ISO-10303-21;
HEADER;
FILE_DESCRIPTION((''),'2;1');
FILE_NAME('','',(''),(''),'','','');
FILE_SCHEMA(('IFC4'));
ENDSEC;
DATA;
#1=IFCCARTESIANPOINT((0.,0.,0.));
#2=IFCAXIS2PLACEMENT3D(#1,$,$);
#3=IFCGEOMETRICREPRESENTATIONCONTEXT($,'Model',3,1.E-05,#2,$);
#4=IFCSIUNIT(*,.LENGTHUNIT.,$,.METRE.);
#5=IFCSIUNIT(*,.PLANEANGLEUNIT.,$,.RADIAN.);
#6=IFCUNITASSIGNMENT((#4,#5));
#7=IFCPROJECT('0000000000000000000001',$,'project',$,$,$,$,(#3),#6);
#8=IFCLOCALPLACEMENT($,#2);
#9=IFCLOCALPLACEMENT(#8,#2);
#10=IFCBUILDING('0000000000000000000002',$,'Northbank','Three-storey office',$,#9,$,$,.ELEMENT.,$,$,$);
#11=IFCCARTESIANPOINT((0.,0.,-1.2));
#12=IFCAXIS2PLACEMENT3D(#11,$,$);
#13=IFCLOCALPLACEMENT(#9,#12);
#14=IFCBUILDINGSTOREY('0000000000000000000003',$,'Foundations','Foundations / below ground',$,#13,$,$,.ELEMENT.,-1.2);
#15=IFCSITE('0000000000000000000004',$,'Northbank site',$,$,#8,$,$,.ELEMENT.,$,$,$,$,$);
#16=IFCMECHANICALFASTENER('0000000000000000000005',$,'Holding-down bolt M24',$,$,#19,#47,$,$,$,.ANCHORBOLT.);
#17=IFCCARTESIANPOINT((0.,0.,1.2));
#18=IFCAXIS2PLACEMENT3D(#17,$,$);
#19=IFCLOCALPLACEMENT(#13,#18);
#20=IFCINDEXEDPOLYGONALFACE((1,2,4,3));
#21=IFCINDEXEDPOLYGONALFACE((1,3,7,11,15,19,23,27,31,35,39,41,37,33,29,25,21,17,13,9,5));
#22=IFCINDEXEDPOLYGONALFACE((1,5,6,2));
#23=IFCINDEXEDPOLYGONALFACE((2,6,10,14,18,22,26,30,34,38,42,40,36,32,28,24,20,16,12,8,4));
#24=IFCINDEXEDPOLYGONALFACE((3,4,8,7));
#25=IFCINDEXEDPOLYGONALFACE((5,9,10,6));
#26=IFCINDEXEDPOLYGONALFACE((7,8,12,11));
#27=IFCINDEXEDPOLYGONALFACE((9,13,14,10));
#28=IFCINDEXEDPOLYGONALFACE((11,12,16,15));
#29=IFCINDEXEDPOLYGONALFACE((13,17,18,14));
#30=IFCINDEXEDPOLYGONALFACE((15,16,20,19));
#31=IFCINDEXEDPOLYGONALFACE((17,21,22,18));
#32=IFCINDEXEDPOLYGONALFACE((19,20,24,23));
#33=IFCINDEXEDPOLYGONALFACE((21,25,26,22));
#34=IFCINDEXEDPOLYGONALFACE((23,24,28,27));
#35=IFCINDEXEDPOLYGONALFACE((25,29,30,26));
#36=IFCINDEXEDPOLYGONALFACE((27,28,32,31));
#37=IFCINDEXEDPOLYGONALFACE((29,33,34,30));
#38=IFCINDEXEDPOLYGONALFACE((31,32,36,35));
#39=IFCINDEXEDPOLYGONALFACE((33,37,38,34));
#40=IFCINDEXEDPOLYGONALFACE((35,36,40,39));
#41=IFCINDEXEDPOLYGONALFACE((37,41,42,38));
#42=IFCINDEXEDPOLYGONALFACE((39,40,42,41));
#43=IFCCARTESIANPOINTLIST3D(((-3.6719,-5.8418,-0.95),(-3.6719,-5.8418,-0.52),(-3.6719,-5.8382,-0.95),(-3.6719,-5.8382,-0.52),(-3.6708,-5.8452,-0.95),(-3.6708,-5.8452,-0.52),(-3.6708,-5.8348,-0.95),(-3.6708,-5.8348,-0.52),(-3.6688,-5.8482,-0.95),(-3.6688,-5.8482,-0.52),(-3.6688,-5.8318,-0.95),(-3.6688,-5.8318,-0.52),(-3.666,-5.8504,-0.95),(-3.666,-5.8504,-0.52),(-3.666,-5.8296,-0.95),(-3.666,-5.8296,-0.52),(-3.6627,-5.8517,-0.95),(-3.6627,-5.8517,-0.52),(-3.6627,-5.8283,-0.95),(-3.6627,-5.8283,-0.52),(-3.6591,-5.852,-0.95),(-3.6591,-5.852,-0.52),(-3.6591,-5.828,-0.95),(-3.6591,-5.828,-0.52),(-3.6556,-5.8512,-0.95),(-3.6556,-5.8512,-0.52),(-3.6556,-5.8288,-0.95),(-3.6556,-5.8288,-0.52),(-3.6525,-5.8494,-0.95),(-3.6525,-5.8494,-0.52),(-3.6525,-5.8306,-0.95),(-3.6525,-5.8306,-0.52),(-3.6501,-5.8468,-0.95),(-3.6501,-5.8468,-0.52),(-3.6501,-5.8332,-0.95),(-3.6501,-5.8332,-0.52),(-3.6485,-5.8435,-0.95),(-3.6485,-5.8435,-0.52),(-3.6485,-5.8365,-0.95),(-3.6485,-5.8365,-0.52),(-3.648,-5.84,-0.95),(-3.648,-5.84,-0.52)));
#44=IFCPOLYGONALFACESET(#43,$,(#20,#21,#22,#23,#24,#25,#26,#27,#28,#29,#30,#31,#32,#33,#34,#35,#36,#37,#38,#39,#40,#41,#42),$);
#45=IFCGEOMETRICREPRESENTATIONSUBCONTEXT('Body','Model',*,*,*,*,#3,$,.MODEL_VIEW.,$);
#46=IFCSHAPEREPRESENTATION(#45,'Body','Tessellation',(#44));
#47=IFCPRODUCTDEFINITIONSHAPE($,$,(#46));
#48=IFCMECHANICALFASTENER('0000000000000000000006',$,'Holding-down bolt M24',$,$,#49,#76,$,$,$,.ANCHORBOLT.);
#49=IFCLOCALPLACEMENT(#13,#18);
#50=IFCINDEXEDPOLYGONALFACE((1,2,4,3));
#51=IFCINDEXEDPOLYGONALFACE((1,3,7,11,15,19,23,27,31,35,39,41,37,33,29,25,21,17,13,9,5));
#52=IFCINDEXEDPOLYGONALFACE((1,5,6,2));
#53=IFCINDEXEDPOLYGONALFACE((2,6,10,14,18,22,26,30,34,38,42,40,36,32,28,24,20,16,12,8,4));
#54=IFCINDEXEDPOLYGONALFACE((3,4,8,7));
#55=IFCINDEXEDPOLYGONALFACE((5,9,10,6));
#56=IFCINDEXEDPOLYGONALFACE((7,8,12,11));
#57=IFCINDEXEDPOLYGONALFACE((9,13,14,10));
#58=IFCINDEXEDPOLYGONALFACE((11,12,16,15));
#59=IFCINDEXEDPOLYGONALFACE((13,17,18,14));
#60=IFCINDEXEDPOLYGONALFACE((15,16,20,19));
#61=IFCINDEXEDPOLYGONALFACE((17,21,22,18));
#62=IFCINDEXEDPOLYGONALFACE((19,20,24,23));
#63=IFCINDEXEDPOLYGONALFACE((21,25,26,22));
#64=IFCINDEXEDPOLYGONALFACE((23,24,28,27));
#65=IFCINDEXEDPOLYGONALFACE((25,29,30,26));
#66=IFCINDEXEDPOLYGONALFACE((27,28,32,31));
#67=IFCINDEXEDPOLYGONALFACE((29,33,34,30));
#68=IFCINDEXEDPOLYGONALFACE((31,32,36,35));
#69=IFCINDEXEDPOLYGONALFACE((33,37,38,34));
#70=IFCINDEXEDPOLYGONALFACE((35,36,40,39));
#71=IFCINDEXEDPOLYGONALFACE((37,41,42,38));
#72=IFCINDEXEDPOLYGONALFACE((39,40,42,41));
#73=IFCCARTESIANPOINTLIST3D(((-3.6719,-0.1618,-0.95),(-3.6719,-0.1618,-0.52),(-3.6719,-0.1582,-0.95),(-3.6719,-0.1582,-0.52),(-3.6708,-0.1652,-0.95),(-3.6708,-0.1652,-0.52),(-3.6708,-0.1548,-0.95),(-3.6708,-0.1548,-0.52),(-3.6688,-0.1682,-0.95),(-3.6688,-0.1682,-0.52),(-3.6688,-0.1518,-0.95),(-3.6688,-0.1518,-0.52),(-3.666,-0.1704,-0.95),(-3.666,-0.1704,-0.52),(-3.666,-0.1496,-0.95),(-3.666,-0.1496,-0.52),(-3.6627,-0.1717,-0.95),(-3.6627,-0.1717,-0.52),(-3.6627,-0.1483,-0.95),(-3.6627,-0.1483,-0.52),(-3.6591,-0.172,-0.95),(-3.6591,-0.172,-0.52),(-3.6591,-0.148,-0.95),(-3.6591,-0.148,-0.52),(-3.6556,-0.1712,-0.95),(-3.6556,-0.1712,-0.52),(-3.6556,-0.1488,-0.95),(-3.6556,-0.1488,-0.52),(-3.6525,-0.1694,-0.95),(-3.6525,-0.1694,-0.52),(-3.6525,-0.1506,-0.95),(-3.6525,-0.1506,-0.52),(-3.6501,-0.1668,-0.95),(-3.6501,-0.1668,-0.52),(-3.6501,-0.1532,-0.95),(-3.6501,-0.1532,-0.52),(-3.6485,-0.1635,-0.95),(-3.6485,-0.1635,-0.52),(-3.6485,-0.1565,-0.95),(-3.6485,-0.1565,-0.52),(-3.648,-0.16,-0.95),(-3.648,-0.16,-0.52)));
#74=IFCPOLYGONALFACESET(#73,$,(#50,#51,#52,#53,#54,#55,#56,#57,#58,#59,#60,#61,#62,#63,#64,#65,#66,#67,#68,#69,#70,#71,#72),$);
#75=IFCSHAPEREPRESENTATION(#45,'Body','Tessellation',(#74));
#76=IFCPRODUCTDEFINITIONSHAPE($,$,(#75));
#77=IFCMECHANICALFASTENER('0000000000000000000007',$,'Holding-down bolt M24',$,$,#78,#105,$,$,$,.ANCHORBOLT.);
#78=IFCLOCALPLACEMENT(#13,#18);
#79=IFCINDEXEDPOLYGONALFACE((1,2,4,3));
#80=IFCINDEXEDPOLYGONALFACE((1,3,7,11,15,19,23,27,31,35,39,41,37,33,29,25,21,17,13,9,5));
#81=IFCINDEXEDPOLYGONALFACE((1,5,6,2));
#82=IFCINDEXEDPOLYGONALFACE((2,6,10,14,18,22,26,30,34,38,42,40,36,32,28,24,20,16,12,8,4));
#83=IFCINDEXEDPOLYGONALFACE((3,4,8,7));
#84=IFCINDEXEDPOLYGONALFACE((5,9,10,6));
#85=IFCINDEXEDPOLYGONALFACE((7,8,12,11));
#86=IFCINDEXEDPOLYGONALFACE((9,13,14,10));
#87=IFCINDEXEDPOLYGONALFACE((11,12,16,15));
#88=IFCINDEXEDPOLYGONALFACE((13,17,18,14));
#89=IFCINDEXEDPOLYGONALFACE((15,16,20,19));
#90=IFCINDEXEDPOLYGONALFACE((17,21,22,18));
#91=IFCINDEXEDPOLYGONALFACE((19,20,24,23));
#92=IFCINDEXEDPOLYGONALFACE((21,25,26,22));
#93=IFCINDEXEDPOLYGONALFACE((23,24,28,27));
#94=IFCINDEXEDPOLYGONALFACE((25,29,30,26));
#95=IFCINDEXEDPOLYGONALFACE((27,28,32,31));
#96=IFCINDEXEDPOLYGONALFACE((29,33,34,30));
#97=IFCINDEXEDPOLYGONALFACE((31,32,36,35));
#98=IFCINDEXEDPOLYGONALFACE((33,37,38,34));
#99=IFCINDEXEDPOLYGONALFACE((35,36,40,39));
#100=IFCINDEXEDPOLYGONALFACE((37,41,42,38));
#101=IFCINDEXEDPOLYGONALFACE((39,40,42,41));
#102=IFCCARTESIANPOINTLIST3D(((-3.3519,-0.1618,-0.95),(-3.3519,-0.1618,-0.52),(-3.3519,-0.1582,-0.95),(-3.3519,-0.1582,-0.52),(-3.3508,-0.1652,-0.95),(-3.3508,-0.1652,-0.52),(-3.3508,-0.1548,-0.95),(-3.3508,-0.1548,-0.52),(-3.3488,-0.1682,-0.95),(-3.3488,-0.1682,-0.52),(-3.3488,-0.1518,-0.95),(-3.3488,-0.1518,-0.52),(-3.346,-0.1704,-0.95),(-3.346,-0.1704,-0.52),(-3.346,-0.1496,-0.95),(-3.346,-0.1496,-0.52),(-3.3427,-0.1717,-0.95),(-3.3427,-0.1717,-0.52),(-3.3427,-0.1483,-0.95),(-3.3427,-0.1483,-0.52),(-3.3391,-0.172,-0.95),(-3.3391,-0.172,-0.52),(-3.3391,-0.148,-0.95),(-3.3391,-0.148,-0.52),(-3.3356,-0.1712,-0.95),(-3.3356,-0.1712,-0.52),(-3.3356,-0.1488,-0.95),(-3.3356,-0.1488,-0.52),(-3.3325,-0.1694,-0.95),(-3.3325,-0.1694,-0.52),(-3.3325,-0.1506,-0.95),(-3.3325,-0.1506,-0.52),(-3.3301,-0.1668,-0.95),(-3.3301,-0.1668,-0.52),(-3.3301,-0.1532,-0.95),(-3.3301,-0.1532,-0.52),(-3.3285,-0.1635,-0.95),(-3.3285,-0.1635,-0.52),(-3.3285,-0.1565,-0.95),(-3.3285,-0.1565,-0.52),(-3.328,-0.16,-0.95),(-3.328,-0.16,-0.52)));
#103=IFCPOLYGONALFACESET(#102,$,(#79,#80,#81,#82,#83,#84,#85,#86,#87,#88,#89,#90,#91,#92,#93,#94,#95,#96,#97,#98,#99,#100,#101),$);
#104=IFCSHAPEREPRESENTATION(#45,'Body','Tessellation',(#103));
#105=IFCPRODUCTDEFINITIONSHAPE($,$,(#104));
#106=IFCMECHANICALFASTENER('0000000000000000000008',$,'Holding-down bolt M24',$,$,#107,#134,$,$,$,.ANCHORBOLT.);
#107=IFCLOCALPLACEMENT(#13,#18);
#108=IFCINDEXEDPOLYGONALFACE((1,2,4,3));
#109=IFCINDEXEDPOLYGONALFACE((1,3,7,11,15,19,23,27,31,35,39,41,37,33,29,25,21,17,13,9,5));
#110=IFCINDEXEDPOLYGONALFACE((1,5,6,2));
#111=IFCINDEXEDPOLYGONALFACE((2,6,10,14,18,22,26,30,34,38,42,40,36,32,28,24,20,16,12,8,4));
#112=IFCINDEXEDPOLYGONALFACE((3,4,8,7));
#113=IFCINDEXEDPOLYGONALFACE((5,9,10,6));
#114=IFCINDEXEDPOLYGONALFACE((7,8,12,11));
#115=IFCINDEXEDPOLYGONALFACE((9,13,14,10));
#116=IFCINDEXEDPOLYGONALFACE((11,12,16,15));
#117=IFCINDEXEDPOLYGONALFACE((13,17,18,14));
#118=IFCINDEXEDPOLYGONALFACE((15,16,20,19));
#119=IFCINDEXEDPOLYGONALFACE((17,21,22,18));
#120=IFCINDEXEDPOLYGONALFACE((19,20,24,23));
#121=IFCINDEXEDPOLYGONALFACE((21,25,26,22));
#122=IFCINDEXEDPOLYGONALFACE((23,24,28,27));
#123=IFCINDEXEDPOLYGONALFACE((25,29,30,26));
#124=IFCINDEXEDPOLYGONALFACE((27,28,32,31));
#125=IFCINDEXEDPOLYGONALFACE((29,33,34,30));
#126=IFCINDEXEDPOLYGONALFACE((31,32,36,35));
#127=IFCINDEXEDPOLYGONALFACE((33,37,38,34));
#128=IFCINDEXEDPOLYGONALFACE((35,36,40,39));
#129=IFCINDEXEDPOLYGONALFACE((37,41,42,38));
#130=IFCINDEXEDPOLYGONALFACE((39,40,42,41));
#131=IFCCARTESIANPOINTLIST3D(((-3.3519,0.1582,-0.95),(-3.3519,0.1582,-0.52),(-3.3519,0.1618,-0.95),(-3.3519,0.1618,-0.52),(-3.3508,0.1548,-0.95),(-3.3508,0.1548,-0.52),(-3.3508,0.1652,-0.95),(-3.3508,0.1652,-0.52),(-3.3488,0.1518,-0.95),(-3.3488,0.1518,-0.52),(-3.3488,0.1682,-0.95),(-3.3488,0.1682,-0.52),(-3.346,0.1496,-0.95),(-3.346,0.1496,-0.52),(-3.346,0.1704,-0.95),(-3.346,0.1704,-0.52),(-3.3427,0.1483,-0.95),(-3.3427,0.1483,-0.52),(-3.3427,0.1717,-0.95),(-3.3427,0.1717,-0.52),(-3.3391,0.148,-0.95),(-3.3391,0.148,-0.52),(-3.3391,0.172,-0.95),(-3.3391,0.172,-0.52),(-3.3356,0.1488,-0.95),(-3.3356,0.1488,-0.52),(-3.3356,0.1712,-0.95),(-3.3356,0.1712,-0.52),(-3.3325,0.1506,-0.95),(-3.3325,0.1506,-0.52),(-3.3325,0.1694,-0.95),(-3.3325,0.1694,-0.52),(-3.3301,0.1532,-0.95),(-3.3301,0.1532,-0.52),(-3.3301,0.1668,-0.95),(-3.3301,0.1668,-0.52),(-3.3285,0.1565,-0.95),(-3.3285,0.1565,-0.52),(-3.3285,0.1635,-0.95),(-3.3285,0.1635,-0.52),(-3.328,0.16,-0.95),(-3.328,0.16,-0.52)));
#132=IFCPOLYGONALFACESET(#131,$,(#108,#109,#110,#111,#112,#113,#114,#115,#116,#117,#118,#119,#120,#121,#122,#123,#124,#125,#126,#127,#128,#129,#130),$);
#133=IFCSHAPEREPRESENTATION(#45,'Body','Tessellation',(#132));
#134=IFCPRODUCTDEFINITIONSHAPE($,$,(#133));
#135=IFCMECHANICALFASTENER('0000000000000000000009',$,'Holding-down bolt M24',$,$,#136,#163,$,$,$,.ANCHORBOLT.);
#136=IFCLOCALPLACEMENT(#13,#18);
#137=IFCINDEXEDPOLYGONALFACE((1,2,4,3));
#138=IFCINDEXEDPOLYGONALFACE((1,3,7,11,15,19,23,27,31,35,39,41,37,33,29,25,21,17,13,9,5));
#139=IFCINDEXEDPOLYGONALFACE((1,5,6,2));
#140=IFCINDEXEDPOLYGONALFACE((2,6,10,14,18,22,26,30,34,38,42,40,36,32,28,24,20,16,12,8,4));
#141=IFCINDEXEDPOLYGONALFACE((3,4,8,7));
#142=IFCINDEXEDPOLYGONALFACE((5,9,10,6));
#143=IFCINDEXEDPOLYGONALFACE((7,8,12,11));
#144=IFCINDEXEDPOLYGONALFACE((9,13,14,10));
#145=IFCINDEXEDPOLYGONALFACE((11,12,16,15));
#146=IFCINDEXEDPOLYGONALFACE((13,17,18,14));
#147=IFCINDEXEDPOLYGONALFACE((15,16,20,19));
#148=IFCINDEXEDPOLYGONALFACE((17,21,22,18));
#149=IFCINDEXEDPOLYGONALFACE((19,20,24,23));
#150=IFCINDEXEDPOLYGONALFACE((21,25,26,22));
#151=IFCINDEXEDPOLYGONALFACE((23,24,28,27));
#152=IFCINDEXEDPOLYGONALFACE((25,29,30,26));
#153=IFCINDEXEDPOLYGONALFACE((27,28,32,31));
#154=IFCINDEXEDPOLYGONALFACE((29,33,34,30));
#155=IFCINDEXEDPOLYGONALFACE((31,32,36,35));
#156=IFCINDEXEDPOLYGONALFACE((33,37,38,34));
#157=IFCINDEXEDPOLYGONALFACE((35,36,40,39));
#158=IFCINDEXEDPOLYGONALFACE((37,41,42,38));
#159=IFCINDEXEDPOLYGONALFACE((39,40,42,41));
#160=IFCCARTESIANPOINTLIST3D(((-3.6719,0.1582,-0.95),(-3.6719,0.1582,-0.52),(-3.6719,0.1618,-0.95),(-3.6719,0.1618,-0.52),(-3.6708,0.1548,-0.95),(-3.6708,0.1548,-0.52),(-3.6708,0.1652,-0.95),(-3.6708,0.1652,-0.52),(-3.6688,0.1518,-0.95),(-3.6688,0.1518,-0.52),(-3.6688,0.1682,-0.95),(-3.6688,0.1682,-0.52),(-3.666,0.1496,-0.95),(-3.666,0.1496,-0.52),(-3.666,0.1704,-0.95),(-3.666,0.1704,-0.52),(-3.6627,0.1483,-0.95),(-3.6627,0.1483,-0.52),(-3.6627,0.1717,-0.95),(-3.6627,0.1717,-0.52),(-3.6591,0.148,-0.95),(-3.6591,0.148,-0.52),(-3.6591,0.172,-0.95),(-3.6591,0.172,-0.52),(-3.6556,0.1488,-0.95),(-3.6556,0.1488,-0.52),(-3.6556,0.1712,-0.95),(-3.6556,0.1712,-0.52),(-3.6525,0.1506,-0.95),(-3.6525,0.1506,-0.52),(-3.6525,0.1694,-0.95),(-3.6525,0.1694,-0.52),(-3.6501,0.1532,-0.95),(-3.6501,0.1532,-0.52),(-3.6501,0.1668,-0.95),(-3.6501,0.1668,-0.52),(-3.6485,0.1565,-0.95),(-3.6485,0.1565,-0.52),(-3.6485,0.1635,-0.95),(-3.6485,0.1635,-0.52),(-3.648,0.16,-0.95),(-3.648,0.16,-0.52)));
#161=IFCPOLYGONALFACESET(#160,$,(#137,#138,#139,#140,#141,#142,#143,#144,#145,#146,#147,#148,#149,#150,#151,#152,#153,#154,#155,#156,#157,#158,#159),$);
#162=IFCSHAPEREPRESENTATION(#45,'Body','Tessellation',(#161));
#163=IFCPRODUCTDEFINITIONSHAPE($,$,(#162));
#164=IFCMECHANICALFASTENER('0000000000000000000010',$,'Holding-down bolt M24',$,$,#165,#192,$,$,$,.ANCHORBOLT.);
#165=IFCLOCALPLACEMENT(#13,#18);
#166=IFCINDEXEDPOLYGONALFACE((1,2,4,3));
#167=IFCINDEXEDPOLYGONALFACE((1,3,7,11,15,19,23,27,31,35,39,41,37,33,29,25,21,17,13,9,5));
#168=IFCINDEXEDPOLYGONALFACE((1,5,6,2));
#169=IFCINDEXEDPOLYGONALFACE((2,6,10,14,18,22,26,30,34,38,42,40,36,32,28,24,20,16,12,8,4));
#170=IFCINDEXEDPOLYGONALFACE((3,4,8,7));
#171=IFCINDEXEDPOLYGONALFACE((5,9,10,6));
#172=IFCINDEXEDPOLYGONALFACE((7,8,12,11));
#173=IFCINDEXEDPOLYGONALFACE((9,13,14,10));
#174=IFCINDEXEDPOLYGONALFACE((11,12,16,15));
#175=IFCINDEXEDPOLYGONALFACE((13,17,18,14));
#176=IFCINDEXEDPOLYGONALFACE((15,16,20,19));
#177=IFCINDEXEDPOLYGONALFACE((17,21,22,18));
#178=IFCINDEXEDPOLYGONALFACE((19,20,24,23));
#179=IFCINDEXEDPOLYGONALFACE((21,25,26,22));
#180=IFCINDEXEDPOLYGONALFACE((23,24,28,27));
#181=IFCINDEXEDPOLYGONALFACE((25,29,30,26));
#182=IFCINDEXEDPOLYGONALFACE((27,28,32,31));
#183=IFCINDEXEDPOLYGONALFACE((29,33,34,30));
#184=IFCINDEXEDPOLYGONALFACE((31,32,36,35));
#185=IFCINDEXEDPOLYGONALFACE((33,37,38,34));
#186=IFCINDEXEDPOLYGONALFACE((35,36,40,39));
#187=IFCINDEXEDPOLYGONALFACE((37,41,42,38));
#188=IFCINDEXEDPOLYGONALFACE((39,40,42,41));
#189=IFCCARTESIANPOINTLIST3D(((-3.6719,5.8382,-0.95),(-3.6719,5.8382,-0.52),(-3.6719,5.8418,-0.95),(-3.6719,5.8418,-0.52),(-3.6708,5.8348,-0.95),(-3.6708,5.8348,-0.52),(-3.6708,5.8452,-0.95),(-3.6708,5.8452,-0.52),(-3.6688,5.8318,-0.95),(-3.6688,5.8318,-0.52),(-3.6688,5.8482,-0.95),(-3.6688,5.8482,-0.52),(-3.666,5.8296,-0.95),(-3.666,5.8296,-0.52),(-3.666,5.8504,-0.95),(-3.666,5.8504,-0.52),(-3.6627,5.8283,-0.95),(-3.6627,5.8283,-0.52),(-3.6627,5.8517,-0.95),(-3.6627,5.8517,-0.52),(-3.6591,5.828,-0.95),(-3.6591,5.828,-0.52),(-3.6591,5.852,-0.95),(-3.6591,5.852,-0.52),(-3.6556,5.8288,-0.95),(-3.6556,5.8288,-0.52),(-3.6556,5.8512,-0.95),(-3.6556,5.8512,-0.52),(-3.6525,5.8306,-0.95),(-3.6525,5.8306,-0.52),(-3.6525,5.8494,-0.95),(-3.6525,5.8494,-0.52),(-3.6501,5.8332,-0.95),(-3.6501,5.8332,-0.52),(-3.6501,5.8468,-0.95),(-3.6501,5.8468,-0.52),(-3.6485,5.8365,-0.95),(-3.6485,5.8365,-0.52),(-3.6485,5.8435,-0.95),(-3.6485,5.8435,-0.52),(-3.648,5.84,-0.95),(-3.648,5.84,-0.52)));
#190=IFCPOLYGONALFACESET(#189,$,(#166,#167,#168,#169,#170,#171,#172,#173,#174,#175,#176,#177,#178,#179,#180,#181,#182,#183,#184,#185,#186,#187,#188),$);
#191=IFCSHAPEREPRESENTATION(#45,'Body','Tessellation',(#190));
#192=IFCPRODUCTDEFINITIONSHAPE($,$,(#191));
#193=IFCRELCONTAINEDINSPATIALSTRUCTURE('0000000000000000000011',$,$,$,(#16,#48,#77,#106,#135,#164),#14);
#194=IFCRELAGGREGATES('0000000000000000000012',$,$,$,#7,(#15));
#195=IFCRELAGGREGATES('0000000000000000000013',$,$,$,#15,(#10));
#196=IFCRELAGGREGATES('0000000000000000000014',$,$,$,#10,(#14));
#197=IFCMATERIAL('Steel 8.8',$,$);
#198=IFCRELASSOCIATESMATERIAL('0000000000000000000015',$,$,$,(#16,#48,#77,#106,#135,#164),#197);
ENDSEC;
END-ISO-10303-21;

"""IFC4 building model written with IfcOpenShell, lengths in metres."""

from ifc_helpers import new_model, si_unit, frame, origin, place, context, subcontext, project, spatial, circle, extrude, material, element, save


model = new_model("IFC4")

# Units and contexts
model_context = context("Model", 3, precision=1e-05, world=origin())
body_context = subcontext(model_context, "Body", "Model", "MODEL_VIEW")
ifc_project = project(units=[si_unit("LENGTHUNIT", "METRE"), si_unit("PLANEANGLEUNIT", "RADIAN")], contexts=[model_context])

# Site, building, storey
site_placement = place(None, origin())
site = spatial("IfcSite", under=ifc_project, at=site_placement, Name="Northbank site", CompositionType="ELEMENT")
building_placement = place(site_placement, origin())
building = spatial("IfcBuilding", under=site, at=building_placement, Name="Northbank", Description="Three-storey office", CompositionType="ELEMENT")
storey_placement = place(building_placement, frame((0.0, 0.0, -1.2)))
storey = spatial("IfcBuildingStorey", under=building, at=storey_placement, Name="Foundations", Description="Foundations / below ground", CompositionType="ELEMENT", Elevation=-1.2)

# Mechanical fasteners
ifc_material_1 = material(Name="Steel 8.8")
mechanical_fastener_1_placement = place(storey_placement, frame((0.0, 0.0, 1.2)))
element("IfcMechanicalFastener", 1, at=mechanical_fastener_1_placement, inside=storey, material=ifc_material_1, Name="Holding-down bolt M24", PredefinedType="ANCHORBOLT", context=body_context, shape_type="SweptSolid", body=[
    extrude(circle(Radius=0.012), frame((-3.66, -5.84, -0.95), z_axis=(0.0, 0.0, 1.0), x_axis=(1.0, 0.0, 0.0)), (0.0, 0.0, 1.0), 0.43),
])
mechanical_fastener_2_placement = place(storey_placement, frame((0.0, 0.0, 1.2)))
element("IfcMechanicalFastener", 2, at=mechanical_fastener_2_placement, inside=storey, material=ifc_material_1, Name="Holding-down bolt M24", PredefinedType="ANCHORBOLT", context=body_context, shape_type="SweptSolid", body=[
    extrude(circle(Radius=0.012), frame((-3.66, -0.16, -0.95), z_axis=(0.0, 0.0, 1.0), x_axis=(1.0, 0.0, 0.0)), (0.0, 0.0, 1.0), 0.43),
])
mechanical_fastener_3_placement = place(storey_placement, frame((0.0, 0.0, 1.2)))
element("IfcMechanicalFastener", 3, at=mechanical_fastener_3_placement, inside=storey, material=ifc_material_1, Name="Holding-down bolt M24", PredefinedType="ANCHORBOLT", context=body_context, shape_type="SweptSolid", body=[
    extrude(circle(Radius=0.012), frame((-3.34, -0.16, -0.95), z_axis=(0.0, 0.0, 1.0), x_axis=(1.0, 0.0, 0.0)), (0.0, 0.0, 1.0), 0.43),
])
mechanical_fastener_4_placement = place(storey_placement, frame((0.0, 0.0, 1.2)))
element("IfcMechanicalFastener", 4, at=mechanical_fastener_4_placement, inside=storey, material=ifc_material_1, Name="Holding-down bolt M24", PredefinedType="ANCHORBOLT", context=body_context, shape_type="SweptSolid", body=[
    extrude(circle(Radius=0.012), frame((-3.34, 0.16, -0.95), z_axis=(0.0, 0.0, 1.0), x_axis=(1.0, 0.0, 0.0)), (0.0, 0.0, 1.0), 0.43),
])
mechanical_fastener_5_placement = place(storey_placement, frame((0.0, 0.0, 1.2)))
element("IfcMechanicalFastener", 5, at=mechanical_fastener_5_placement, inside=storey, material=ifc_material_1, Name="Holding-down bolt M24", PredefinedType="ANCHORBOLT", context=body_context, shape_type="SweptSolid", body=[
    extrude(circle(Radius=0.012), frame((-3.66, 0.16, -0.95), z_axis=(0.0, 0.0, 1.0), x_axis=(1.0, 0.0, 0.0)), (0.0, 0.0, 1.0), 0.43),
])
mechanical_fastener_6_placement = place(storey_placement, frame((0.0, 0.0, 1.2)))
element("IfcMechanicalFastener", 6, at=mechanical_fastener_6_placement, inside=storey, material=ifc_material_1, Name="Holding-down bolt M24", PredefinedType="ANCHORBOLT", context=body_context, shape_type="SweptSolid", body=[
    extrude(circle(Radius=0.012), frame((-3.66, 5.84, -0.95), z_axis=(0.0, 0.0, 1.0), x_axis=(1.0, 0.0, 0.0)), (0.0, 0.0, 1.0), 0.43),
])

save(model, "model.ifc")
